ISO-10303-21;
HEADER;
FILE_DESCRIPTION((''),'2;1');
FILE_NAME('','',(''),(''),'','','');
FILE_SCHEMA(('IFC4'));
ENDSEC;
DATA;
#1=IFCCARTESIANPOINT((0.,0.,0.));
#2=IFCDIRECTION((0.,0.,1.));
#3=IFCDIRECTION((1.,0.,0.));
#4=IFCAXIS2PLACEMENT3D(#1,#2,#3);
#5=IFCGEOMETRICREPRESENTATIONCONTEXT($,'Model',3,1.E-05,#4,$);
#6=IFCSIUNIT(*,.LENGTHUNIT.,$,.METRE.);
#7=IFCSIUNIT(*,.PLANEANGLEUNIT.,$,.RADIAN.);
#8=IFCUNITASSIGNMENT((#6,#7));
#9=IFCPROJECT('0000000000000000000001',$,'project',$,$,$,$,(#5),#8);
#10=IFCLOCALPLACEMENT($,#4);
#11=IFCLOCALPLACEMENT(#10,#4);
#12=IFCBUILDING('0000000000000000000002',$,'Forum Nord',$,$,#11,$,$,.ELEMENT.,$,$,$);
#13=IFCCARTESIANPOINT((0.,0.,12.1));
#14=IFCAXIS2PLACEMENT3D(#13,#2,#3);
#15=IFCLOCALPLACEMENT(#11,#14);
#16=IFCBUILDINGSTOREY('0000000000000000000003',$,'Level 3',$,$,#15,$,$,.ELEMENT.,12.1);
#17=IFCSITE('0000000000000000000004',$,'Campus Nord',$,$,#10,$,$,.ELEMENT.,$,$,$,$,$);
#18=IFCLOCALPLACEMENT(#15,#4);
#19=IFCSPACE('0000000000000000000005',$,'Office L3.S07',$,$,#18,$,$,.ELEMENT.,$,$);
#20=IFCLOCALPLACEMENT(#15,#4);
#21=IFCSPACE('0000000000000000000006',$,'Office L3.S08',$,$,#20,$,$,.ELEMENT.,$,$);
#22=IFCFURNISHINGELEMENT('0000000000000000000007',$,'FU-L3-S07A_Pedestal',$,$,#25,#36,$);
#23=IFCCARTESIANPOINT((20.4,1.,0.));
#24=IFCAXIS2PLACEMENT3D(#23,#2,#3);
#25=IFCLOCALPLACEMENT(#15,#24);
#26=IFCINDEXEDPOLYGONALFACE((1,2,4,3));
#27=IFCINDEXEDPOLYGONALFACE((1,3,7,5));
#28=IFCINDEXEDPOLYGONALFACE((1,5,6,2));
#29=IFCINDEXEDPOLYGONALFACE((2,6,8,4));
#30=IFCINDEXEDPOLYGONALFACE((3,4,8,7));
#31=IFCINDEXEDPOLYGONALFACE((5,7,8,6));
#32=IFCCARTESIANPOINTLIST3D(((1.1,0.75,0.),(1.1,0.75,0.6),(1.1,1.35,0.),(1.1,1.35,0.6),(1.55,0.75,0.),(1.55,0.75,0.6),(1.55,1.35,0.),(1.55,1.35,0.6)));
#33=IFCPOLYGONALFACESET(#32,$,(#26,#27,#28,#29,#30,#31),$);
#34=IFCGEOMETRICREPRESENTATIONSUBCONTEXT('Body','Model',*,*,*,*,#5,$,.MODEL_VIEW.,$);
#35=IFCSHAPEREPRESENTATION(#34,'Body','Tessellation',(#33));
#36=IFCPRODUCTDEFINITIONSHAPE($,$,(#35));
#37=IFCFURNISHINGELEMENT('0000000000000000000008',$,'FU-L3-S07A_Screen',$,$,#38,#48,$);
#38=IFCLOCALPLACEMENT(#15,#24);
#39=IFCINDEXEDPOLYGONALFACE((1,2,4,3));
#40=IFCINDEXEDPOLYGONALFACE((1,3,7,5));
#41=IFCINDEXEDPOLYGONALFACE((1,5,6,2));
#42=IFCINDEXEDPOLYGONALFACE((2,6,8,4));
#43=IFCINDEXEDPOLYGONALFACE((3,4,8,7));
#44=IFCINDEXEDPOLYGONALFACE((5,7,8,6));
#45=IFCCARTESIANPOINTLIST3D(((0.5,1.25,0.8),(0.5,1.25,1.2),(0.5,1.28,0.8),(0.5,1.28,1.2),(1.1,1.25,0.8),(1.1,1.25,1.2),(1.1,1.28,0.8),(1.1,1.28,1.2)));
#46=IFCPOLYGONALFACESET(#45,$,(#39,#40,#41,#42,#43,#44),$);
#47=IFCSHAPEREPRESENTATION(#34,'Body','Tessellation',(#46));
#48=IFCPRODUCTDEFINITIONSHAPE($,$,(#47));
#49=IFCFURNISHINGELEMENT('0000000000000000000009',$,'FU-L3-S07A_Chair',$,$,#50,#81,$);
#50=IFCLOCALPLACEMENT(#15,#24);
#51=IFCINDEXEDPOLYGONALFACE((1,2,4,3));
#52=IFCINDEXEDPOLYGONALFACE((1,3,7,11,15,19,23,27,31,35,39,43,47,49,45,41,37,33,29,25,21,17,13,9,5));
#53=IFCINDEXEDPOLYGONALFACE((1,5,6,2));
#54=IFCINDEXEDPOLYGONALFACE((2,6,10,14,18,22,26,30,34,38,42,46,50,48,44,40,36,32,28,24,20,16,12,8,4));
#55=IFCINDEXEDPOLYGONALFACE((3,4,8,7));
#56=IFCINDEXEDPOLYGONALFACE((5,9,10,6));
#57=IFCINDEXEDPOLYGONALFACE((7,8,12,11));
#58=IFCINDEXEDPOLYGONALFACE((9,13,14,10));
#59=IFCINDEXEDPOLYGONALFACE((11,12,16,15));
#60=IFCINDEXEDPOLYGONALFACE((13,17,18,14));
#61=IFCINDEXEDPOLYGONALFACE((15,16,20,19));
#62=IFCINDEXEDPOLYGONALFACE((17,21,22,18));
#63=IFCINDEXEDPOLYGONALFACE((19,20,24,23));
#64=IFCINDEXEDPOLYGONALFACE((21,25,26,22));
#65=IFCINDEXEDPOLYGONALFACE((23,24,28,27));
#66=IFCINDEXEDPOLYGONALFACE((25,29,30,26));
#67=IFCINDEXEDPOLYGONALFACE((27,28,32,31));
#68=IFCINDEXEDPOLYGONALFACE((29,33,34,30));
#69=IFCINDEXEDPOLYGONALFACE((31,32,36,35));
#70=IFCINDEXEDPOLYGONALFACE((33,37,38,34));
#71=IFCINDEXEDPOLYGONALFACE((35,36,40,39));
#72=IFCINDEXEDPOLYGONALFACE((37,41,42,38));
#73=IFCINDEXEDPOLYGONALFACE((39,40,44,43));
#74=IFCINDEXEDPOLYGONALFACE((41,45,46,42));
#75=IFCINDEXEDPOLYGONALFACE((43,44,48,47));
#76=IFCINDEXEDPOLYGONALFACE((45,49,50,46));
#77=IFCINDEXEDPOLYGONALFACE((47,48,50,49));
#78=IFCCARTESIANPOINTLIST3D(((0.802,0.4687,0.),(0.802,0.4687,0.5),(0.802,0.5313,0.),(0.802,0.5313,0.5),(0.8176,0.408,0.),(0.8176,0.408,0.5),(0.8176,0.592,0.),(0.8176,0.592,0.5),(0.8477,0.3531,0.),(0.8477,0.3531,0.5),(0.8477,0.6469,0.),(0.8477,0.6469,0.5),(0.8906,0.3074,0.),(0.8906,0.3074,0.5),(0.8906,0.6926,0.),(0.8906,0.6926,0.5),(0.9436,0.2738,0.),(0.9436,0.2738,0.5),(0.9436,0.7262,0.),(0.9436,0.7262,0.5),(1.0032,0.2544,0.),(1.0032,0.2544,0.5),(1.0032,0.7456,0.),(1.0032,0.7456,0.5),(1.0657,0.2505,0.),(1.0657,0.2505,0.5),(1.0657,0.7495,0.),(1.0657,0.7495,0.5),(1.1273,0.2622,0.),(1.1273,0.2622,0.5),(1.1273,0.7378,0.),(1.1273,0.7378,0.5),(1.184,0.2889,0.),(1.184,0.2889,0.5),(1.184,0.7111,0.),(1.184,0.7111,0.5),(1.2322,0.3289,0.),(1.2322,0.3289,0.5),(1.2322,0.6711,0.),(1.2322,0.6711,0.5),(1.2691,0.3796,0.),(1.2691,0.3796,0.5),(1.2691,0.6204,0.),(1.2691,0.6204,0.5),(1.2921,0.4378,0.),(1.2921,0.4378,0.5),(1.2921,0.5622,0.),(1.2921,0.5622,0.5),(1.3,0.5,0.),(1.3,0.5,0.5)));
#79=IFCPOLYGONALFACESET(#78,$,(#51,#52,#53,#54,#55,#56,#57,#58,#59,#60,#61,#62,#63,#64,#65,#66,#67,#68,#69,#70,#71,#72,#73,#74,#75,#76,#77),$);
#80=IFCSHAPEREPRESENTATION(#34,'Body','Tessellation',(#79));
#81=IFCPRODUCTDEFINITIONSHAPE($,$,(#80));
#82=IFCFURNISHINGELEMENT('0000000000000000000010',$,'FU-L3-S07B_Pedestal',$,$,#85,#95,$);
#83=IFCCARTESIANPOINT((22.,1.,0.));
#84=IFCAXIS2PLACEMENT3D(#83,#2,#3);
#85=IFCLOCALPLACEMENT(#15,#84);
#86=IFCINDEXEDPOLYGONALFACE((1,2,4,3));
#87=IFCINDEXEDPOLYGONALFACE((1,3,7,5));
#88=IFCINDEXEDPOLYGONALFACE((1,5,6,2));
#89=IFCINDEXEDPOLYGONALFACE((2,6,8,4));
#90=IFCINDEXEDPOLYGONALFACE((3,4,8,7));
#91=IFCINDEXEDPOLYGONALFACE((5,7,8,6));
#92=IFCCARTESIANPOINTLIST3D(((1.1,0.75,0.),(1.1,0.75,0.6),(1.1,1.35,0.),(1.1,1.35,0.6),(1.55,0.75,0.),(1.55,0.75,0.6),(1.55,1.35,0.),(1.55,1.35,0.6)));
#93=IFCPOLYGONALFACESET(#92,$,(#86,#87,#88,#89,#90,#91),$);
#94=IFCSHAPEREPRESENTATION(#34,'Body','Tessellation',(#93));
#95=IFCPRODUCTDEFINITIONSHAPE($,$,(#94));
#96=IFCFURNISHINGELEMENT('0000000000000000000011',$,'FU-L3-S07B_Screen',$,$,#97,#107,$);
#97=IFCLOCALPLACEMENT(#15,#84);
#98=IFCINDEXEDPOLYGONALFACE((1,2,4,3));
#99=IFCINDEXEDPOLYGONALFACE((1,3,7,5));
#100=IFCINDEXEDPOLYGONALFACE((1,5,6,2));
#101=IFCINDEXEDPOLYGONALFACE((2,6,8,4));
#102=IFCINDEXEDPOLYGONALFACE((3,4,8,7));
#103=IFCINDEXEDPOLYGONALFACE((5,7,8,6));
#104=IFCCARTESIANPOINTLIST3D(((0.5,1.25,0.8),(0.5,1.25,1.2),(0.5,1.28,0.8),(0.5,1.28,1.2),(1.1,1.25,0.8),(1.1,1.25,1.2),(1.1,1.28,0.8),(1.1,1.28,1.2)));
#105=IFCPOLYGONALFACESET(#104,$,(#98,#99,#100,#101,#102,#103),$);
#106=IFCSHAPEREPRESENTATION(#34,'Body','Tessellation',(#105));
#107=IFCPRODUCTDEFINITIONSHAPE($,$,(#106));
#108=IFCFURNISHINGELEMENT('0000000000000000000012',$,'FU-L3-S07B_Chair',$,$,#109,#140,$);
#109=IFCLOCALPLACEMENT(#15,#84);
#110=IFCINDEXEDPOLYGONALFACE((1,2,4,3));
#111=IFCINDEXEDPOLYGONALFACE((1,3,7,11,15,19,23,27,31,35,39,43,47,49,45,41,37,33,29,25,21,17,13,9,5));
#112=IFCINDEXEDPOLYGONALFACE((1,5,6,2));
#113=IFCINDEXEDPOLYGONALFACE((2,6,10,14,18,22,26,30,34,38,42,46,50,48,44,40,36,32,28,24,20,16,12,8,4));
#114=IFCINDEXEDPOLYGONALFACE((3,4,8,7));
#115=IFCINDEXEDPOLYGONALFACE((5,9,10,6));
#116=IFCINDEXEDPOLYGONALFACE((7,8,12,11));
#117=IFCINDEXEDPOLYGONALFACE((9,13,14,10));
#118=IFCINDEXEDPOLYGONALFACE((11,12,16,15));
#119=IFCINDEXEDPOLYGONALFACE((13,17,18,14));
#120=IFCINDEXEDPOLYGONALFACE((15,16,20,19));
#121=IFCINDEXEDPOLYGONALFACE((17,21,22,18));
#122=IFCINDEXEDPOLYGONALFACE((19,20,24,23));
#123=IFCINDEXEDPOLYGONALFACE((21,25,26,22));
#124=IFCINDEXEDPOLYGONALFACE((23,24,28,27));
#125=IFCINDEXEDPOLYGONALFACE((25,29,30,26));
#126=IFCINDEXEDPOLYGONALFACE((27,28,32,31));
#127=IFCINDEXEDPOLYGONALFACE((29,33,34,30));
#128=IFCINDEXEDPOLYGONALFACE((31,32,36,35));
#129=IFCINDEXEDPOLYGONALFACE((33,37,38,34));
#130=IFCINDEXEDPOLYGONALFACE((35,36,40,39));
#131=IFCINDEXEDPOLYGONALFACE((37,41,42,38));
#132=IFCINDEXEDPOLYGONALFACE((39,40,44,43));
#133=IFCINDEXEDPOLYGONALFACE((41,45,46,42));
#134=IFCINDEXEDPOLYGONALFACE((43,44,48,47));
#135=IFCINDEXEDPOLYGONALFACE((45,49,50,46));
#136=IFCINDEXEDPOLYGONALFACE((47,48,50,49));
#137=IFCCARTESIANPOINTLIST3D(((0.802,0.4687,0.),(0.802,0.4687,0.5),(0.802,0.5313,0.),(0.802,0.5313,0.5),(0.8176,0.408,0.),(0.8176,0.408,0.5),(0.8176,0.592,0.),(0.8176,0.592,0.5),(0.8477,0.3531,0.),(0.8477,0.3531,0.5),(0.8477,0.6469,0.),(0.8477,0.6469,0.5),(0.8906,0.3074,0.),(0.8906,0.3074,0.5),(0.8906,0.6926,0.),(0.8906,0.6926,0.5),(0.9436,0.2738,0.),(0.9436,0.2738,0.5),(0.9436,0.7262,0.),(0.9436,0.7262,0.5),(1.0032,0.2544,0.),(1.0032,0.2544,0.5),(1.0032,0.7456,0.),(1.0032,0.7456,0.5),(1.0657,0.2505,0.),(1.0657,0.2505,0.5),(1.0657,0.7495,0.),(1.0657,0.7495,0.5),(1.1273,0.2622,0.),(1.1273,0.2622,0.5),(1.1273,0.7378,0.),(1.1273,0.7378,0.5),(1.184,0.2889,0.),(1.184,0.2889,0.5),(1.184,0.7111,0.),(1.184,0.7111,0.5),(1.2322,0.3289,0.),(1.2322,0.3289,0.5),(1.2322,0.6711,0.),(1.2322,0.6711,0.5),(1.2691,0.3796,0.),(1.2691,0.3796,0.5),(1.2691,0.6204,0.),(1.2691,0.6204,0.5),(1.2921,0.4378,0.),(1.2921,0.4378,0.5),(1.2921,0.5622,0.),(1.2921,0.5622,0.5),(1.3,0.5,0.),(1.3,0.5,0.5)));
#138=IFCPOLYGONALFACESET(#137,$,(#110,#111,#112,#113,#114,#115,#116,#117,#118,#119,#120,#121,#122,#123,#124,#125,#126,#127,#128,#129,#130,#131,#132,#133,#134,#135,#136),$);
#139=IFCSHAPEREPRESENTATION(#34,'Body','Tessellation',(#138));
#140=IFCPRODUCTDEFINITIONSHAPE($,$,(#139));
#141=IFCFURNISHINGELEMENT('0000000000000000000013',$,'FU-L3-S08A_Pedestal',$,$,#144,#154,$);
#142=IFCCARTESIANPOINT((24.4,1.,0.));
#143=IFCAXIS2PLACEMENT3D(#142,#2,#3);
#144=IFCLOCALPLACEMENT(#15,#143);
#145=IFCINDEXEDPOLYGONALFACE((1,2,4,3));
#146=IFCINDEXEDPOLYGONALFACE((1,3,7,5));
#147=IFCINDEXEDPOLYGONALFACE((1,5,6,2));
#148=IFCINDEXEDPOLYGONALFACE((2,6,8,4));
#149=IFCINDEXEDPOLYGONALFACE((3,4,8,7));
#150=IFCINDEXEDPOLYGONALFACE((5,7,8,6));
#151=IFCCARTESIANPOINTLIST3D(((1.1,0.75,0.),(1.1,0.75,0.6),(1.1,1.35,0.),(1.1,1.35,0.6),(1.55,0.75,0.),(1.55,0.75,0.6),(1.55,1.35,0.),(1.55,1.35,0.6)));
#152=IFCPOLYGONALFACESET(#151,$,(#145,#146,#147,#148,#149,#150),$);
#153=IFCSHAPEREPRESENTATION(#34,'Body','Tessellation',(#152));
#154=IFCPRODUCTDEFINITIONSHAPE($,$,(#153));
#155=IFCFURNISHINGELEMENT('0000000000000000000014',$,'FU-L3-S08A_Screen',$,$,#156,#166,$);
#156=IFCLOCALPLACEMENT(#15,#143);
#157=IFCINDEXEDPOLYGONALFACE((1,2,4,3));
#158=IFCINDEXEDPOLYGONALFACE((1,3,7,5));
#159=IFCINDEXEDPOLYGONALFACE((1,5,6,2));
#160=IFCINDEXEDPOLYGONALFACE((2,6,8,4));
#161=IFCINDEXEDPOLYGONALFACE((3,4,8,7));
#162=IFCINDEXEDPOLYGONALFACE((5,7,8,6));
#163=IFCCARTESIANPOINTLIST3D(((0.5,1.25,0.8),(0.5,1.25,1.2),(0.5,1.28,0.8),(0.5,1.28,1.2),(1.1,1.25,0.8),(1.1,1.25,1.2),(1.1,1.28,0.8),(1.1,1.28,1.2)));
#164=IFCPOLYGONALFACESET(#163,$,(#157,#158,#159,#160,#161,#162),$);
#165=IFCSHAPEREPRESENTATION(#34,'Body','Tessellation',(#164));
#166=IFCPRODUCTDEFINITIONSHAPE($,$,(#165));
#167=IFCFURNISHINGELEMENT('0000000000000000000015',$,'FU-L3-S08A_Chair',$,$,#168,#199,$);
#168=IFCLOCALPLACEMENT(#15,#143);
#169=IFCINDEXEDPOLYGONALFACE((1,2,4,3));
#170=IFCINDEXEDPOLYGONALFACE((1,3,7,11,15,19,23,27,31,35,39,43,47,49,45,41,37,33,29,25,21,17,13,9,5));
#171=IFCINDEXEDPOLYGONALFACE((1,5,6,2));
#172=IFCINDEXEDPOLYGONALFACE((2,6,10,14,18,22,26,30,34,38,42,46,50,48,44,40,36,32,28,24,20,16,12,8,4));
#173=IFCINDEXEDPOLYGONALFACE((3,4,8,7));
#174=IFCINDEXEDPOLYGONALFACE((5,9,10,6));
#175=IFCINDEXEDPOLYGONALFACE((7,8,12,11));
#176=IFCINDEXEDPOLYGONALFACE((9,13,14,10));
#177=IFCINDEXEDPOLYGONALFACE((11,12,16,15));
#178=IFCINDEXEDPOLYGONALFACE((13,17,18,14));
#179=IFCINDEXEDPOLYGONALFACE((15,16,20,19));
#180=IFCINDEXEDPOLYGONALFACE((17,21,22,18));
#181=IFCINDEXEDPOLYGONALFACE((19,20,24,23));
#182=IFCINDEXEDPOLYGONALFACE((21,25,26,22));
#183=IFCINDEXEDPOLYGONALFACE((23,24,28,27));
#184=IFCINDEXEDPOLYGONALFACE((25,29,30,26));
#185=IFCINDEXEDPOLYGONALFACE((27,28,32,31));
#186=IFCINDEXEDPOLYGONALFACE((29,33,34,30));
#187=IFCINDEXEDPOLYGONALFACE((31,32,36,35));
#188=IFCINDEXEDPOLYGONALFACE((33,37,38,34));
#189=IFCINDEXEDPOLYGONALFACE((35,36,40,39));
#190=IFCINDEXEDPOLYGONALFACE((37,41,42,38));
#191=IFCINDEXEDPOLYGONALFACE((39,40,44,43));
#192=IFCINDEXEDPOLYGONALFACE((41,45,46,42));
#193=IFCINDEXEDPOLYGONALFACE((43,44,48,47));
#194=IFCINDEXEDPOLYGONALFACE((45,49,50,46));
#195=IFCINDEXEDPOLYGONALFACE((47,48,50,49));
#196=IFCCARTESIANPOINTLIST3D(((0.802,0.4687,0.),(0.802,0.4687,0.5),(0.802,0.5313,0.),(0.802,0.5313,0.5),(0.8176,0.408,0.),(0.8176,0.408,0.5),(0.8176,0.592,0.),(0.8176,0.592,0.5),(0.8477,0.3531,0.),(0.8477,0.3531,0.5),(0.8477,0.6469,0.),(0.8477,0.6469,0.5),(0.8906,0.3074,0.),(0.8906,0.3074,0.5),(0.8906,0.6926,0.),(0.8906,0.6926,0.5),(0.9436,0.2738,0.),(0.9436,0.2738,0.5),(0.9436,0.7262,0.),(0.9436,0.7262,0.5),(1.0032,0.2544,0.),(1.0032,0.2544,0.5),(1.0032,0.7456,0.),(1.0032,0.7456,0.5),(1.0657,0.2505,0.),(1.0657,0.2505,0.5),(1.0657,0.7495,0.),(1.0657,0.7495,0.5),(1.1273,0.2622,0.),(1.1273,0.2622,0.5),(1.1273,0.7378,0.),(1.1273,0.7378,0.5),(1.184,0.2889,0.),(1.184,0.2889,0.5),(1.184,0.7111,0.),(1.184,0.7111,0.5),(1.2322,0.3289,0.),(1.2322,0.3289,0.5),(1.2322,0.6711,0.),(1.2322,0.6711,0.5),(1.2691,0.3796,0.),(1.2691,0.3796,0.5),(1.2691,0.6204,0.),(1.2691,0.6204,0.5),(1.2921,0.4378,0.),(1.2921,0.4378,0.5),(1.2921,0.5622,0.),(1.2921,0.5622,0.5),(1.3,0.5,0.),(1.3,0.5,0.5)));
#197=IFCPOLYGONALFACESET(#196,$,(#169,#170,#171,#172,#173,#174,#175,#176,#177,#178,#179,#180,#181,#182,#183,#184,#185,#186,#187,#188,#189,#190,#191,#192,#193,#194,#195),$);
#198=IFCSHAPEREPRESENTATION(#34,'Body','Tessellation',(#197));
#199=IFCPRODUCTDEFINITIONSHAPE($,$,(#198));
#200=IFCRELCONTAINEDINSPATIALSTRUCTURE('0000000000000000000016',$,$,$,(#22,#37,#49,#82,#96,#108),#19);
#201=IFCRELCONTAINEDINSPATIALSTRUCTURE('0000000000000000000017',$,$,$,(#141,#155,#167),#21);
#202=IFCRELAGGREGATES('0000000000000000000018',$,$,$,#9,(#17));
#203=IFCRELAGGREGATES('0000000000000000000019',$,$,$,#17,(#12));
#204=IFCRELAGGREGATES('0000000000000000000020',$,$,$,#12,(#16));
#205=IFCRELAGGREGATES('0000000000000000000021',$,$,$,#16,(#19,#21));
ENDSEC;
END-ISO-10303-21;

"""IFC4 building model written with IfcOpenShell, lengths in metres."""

from ifc_helpers import new_model, si_unit, frame, frame_2d, origin_with_axes, place, context, subcontext, project, spatial, rectangle, circle, extrude, element, save


model = new_model("IFC4")

# Units and contexts
model_context = context("Model", 3, precision=1e-05, world=origin_with_axes())
body_context = subcontext(model_context, "Body", "Model", "MODEL_VIEW")
ifc_project = project(units=[si_unit("LENGTHUNIT", "METRE"), si_unit("PLANEANGLEUNIT", "RADIAN")], contexts=[model_context])

# Site, building, storey
site_placement = place(None, origin_with_axes())
site = spatial("IfcSite", under=ifc_project, at=site_placement, Name="Campus Nord", CompositionType="ELEMENT")
building_placement = place(site_placement, origin_with_axes())
building = spatial("IfcBuilding", under=site, at=building_placement, Name="Forum Nord", CompositionType="ELEMENT")
storey_placement = place(building_placement, frame((0.0, 0.0, 12.1), z_axis=(0.0, 0.0, 1.0), x_axis=(1.0, 0.0, 0.0)))
storey = spatial("IfcBuildingStorey", under=building, at=storey_placement, Name="Level 3", CompositionType="ELEMENT", Elevation=12.1)

# Shared definitions
space_1_placement = place(storey_placement, origin_with_axes())
space_1 = spatial("IfcSpace", under=storey, at=space_1_placement, Name="Office L3.S07", CompositionType="ELEMENT")

# Furnishing elements
furnishing_1_placement = place(storey_placement, frame((20.4, 1.0, 0.0), z_axis=(0.0, 0.0, 1.0), x_axis=(1.0, 0.0, 0.0)))
element("IfcFurnishingElement", 1, at=furnishing_1_placement, inside=space_1, Name="FU-L3-S07A_Pedestal", context=body_context, shape_type="SweptSolid", body=[
    extrude(rectangle(XDim=0.45, YDim=0.6, at=frame_2d((1.325, 1.05), x_axis=(1.0, 0.0))), origin_with_axes(), (0.0, 0.0, 1.0), 0.6),
])
furnishing_2_placement = place(storey_placement, frame((20.4, 1.0, 0.0), z_axis=(0.0, 0.0, 1.0), x_axis=(1.0, 0.0, 0.0)))
element("IfcFurnishingElement", 2, at=furnishing_2_placement, inside=space_1, Name="FU-L3-S07A_Screen", context=body_context, shape_type="SweptSolid", body=[
    extrude(rectangle(XDim=0.6, YDim=0.03, at=frame_2d((0.8, 1.265), x_axis=(1.0, 0.0))), frame((0.0, 0.0, 0.8), z_axis=(0.0, 0.0, 1.0), x_axis=(1.0, 0.0, 0.0)), (0.0, 0.0, 1.0), 0.4),
])
furnishing_3_placement = place(storey_placement, frame((20.4, 1.0, 0.0), z_axis=(0.0, 0.0, 1.0), x_axis=(1.0, 0.0, 0.0)))
element("IfcFurnishingElement", 3, at=furnishing_3_placement, inside=space_1, Name="FU-L3-S07A_Chair", context=body_context, shape_type="SweptSolid", body=[
    extrude(circle(Radius=0.25, at=frame_2d((1.05, 0.5), x_axis=(1.0, 0.0))), origin_with_axes(), (0.0, 0.0, 1.0), 0.5),
])
furnishing_4_placement = place(storey_placement, frame((22.0, 1.0, 0.0), z_axis=(0.0, 0.0, 1.0), x_axis=(1.0, 0.0, 0.0)))
element("IfcFurnishingElement", 4, at=furnishing_4_placement, inside=space_1, Name="FU-L3-S07B_Pedestal", context=body_context, shape_type="SweptSolid", body=[
    extrude(rectangle(XDim=0.45, YDim=0.6, at=frame_2d((1.325, 1.05), x_axis=(1.0, 0.0))), origin_with_axes(), (0.0, 0.0, 1.0), 0.6),
])
furnishing_5_placement = place(storey_placement, frame((22.0, 1.0, 0.0), z_axis=(0.0, 0.0, 1.0), x_axis=(1.0, 0.0, 0.0)))
element("IfcFurnishingElement", 5, at=furnishing_5_placement, inside=space_1, Name="FU-L3-S07B_Screen", context=body_context, shape_type="SweptSolid", body=[
    extrude(rectangle(XDim=0.6, YDim=0.03, at=frame_2d((0.8, 1.265), x_axis=(1.0, 0.0))), frame((0.0, 0.0, 0.8), z_axis=(0.0, 0.0, 1.0), x_axis=(1.0, 0.0, 0.0)), (0.0, 0.0, 1.0), 0.4),
])
furnishing_6_placement = place(storey_placement, frame((22.0, 1.0, 0.0), z_axis=(0.0, 0.0, 1.0), x_axis=(1.0, 0.0, 0.0)))
element("IfcFurnishingElement", 6, at=furnishing_6_placement, inside=space_1, Name="FU-L3-S07B_Chair", context=body_context, shape_type="SweptSolid", body=[
    extrude(circle(Radius=0.25, at=frame_2d((1.05, 0.5), x_axis=(1.0, 0.0))), origin_with_axes(), (0.0, 0.0, 1.0), 0.5),
])

# Shared definitions
space_2_placement = place(storey_placement, origin_with_axes())
space_2 = spatial("IfcSpace", under=storey, at=space_2_placement, Name="Office L3.S08", CompositionType="ELEMENT")

# Furnishing elements
furnishing_7_placement = place(storey_placement, frame((24.4, 1.0, 0.0), z_axis=(0.0, 0.0, 1.0), x_axis=(1.0, 0.0, 0.0)))
element("IfcFurnishingElement", 7, at=furnishing_7_placement, inside=space_2, Name="FU-L3-S08A_Pedestal", context=body_context, shape_type="SweptSolid", body=[
    extrude(rectangle(XDim=0.45, YDim=0.6, at=frame_2d((1.325, 1.05), x_axis=(1.0, 0.0))), origin_with_axes(), (0.0, 0.0, 1.0), 0.6),
])
furnishing_8_placement = place(storey_placement, frame((24.4, 1.0, 0.0), z_axis=(0.0, 0.0, 1.0), x_axis=(1.0, 0.0, 0.0)))
element("IfcFurnishingElement", 8, at=furnishing_8_placement, inside=space_2, Name="FU-L3-S08A_Screen", context=body_context, shape_type="SweptSolid", body=[
    extrude(rectangle(XDim=0.6, YDim=0.03, at=frame_2d((0.8, 1.265), x_axis=(1.0, 0.0))), frame((0.0, 0.0, 0.8), z_axis=(0.0, 0.0, 1.0), x_axis=(1.0, 0.0, 0.0)), (0.0, 0.0, 1.0), 0.4),
])
furnishing_9_placement = place(storey_placement, frame((24.4, 1.0, 0.0), z_axis=(0.0, 0.0, 1.0), x_axis=(1.0, 0.0, 0.0)))
element("IfcFurnishingElement", 9, at=furnishing_9_placement, inside=space_2, Name="FU-L3-S08A_Chair", context=body_context, shape_type="SweptSolid", body=[
    extrude(circle(Radius=0.25, at=frame_2d((1.05, 0.5), x_axis=(1.0, 0.0))), origin_with_axes(), (0.0, 0.0, 1.0), 0.5),
])

save(model, "model.ifc")
